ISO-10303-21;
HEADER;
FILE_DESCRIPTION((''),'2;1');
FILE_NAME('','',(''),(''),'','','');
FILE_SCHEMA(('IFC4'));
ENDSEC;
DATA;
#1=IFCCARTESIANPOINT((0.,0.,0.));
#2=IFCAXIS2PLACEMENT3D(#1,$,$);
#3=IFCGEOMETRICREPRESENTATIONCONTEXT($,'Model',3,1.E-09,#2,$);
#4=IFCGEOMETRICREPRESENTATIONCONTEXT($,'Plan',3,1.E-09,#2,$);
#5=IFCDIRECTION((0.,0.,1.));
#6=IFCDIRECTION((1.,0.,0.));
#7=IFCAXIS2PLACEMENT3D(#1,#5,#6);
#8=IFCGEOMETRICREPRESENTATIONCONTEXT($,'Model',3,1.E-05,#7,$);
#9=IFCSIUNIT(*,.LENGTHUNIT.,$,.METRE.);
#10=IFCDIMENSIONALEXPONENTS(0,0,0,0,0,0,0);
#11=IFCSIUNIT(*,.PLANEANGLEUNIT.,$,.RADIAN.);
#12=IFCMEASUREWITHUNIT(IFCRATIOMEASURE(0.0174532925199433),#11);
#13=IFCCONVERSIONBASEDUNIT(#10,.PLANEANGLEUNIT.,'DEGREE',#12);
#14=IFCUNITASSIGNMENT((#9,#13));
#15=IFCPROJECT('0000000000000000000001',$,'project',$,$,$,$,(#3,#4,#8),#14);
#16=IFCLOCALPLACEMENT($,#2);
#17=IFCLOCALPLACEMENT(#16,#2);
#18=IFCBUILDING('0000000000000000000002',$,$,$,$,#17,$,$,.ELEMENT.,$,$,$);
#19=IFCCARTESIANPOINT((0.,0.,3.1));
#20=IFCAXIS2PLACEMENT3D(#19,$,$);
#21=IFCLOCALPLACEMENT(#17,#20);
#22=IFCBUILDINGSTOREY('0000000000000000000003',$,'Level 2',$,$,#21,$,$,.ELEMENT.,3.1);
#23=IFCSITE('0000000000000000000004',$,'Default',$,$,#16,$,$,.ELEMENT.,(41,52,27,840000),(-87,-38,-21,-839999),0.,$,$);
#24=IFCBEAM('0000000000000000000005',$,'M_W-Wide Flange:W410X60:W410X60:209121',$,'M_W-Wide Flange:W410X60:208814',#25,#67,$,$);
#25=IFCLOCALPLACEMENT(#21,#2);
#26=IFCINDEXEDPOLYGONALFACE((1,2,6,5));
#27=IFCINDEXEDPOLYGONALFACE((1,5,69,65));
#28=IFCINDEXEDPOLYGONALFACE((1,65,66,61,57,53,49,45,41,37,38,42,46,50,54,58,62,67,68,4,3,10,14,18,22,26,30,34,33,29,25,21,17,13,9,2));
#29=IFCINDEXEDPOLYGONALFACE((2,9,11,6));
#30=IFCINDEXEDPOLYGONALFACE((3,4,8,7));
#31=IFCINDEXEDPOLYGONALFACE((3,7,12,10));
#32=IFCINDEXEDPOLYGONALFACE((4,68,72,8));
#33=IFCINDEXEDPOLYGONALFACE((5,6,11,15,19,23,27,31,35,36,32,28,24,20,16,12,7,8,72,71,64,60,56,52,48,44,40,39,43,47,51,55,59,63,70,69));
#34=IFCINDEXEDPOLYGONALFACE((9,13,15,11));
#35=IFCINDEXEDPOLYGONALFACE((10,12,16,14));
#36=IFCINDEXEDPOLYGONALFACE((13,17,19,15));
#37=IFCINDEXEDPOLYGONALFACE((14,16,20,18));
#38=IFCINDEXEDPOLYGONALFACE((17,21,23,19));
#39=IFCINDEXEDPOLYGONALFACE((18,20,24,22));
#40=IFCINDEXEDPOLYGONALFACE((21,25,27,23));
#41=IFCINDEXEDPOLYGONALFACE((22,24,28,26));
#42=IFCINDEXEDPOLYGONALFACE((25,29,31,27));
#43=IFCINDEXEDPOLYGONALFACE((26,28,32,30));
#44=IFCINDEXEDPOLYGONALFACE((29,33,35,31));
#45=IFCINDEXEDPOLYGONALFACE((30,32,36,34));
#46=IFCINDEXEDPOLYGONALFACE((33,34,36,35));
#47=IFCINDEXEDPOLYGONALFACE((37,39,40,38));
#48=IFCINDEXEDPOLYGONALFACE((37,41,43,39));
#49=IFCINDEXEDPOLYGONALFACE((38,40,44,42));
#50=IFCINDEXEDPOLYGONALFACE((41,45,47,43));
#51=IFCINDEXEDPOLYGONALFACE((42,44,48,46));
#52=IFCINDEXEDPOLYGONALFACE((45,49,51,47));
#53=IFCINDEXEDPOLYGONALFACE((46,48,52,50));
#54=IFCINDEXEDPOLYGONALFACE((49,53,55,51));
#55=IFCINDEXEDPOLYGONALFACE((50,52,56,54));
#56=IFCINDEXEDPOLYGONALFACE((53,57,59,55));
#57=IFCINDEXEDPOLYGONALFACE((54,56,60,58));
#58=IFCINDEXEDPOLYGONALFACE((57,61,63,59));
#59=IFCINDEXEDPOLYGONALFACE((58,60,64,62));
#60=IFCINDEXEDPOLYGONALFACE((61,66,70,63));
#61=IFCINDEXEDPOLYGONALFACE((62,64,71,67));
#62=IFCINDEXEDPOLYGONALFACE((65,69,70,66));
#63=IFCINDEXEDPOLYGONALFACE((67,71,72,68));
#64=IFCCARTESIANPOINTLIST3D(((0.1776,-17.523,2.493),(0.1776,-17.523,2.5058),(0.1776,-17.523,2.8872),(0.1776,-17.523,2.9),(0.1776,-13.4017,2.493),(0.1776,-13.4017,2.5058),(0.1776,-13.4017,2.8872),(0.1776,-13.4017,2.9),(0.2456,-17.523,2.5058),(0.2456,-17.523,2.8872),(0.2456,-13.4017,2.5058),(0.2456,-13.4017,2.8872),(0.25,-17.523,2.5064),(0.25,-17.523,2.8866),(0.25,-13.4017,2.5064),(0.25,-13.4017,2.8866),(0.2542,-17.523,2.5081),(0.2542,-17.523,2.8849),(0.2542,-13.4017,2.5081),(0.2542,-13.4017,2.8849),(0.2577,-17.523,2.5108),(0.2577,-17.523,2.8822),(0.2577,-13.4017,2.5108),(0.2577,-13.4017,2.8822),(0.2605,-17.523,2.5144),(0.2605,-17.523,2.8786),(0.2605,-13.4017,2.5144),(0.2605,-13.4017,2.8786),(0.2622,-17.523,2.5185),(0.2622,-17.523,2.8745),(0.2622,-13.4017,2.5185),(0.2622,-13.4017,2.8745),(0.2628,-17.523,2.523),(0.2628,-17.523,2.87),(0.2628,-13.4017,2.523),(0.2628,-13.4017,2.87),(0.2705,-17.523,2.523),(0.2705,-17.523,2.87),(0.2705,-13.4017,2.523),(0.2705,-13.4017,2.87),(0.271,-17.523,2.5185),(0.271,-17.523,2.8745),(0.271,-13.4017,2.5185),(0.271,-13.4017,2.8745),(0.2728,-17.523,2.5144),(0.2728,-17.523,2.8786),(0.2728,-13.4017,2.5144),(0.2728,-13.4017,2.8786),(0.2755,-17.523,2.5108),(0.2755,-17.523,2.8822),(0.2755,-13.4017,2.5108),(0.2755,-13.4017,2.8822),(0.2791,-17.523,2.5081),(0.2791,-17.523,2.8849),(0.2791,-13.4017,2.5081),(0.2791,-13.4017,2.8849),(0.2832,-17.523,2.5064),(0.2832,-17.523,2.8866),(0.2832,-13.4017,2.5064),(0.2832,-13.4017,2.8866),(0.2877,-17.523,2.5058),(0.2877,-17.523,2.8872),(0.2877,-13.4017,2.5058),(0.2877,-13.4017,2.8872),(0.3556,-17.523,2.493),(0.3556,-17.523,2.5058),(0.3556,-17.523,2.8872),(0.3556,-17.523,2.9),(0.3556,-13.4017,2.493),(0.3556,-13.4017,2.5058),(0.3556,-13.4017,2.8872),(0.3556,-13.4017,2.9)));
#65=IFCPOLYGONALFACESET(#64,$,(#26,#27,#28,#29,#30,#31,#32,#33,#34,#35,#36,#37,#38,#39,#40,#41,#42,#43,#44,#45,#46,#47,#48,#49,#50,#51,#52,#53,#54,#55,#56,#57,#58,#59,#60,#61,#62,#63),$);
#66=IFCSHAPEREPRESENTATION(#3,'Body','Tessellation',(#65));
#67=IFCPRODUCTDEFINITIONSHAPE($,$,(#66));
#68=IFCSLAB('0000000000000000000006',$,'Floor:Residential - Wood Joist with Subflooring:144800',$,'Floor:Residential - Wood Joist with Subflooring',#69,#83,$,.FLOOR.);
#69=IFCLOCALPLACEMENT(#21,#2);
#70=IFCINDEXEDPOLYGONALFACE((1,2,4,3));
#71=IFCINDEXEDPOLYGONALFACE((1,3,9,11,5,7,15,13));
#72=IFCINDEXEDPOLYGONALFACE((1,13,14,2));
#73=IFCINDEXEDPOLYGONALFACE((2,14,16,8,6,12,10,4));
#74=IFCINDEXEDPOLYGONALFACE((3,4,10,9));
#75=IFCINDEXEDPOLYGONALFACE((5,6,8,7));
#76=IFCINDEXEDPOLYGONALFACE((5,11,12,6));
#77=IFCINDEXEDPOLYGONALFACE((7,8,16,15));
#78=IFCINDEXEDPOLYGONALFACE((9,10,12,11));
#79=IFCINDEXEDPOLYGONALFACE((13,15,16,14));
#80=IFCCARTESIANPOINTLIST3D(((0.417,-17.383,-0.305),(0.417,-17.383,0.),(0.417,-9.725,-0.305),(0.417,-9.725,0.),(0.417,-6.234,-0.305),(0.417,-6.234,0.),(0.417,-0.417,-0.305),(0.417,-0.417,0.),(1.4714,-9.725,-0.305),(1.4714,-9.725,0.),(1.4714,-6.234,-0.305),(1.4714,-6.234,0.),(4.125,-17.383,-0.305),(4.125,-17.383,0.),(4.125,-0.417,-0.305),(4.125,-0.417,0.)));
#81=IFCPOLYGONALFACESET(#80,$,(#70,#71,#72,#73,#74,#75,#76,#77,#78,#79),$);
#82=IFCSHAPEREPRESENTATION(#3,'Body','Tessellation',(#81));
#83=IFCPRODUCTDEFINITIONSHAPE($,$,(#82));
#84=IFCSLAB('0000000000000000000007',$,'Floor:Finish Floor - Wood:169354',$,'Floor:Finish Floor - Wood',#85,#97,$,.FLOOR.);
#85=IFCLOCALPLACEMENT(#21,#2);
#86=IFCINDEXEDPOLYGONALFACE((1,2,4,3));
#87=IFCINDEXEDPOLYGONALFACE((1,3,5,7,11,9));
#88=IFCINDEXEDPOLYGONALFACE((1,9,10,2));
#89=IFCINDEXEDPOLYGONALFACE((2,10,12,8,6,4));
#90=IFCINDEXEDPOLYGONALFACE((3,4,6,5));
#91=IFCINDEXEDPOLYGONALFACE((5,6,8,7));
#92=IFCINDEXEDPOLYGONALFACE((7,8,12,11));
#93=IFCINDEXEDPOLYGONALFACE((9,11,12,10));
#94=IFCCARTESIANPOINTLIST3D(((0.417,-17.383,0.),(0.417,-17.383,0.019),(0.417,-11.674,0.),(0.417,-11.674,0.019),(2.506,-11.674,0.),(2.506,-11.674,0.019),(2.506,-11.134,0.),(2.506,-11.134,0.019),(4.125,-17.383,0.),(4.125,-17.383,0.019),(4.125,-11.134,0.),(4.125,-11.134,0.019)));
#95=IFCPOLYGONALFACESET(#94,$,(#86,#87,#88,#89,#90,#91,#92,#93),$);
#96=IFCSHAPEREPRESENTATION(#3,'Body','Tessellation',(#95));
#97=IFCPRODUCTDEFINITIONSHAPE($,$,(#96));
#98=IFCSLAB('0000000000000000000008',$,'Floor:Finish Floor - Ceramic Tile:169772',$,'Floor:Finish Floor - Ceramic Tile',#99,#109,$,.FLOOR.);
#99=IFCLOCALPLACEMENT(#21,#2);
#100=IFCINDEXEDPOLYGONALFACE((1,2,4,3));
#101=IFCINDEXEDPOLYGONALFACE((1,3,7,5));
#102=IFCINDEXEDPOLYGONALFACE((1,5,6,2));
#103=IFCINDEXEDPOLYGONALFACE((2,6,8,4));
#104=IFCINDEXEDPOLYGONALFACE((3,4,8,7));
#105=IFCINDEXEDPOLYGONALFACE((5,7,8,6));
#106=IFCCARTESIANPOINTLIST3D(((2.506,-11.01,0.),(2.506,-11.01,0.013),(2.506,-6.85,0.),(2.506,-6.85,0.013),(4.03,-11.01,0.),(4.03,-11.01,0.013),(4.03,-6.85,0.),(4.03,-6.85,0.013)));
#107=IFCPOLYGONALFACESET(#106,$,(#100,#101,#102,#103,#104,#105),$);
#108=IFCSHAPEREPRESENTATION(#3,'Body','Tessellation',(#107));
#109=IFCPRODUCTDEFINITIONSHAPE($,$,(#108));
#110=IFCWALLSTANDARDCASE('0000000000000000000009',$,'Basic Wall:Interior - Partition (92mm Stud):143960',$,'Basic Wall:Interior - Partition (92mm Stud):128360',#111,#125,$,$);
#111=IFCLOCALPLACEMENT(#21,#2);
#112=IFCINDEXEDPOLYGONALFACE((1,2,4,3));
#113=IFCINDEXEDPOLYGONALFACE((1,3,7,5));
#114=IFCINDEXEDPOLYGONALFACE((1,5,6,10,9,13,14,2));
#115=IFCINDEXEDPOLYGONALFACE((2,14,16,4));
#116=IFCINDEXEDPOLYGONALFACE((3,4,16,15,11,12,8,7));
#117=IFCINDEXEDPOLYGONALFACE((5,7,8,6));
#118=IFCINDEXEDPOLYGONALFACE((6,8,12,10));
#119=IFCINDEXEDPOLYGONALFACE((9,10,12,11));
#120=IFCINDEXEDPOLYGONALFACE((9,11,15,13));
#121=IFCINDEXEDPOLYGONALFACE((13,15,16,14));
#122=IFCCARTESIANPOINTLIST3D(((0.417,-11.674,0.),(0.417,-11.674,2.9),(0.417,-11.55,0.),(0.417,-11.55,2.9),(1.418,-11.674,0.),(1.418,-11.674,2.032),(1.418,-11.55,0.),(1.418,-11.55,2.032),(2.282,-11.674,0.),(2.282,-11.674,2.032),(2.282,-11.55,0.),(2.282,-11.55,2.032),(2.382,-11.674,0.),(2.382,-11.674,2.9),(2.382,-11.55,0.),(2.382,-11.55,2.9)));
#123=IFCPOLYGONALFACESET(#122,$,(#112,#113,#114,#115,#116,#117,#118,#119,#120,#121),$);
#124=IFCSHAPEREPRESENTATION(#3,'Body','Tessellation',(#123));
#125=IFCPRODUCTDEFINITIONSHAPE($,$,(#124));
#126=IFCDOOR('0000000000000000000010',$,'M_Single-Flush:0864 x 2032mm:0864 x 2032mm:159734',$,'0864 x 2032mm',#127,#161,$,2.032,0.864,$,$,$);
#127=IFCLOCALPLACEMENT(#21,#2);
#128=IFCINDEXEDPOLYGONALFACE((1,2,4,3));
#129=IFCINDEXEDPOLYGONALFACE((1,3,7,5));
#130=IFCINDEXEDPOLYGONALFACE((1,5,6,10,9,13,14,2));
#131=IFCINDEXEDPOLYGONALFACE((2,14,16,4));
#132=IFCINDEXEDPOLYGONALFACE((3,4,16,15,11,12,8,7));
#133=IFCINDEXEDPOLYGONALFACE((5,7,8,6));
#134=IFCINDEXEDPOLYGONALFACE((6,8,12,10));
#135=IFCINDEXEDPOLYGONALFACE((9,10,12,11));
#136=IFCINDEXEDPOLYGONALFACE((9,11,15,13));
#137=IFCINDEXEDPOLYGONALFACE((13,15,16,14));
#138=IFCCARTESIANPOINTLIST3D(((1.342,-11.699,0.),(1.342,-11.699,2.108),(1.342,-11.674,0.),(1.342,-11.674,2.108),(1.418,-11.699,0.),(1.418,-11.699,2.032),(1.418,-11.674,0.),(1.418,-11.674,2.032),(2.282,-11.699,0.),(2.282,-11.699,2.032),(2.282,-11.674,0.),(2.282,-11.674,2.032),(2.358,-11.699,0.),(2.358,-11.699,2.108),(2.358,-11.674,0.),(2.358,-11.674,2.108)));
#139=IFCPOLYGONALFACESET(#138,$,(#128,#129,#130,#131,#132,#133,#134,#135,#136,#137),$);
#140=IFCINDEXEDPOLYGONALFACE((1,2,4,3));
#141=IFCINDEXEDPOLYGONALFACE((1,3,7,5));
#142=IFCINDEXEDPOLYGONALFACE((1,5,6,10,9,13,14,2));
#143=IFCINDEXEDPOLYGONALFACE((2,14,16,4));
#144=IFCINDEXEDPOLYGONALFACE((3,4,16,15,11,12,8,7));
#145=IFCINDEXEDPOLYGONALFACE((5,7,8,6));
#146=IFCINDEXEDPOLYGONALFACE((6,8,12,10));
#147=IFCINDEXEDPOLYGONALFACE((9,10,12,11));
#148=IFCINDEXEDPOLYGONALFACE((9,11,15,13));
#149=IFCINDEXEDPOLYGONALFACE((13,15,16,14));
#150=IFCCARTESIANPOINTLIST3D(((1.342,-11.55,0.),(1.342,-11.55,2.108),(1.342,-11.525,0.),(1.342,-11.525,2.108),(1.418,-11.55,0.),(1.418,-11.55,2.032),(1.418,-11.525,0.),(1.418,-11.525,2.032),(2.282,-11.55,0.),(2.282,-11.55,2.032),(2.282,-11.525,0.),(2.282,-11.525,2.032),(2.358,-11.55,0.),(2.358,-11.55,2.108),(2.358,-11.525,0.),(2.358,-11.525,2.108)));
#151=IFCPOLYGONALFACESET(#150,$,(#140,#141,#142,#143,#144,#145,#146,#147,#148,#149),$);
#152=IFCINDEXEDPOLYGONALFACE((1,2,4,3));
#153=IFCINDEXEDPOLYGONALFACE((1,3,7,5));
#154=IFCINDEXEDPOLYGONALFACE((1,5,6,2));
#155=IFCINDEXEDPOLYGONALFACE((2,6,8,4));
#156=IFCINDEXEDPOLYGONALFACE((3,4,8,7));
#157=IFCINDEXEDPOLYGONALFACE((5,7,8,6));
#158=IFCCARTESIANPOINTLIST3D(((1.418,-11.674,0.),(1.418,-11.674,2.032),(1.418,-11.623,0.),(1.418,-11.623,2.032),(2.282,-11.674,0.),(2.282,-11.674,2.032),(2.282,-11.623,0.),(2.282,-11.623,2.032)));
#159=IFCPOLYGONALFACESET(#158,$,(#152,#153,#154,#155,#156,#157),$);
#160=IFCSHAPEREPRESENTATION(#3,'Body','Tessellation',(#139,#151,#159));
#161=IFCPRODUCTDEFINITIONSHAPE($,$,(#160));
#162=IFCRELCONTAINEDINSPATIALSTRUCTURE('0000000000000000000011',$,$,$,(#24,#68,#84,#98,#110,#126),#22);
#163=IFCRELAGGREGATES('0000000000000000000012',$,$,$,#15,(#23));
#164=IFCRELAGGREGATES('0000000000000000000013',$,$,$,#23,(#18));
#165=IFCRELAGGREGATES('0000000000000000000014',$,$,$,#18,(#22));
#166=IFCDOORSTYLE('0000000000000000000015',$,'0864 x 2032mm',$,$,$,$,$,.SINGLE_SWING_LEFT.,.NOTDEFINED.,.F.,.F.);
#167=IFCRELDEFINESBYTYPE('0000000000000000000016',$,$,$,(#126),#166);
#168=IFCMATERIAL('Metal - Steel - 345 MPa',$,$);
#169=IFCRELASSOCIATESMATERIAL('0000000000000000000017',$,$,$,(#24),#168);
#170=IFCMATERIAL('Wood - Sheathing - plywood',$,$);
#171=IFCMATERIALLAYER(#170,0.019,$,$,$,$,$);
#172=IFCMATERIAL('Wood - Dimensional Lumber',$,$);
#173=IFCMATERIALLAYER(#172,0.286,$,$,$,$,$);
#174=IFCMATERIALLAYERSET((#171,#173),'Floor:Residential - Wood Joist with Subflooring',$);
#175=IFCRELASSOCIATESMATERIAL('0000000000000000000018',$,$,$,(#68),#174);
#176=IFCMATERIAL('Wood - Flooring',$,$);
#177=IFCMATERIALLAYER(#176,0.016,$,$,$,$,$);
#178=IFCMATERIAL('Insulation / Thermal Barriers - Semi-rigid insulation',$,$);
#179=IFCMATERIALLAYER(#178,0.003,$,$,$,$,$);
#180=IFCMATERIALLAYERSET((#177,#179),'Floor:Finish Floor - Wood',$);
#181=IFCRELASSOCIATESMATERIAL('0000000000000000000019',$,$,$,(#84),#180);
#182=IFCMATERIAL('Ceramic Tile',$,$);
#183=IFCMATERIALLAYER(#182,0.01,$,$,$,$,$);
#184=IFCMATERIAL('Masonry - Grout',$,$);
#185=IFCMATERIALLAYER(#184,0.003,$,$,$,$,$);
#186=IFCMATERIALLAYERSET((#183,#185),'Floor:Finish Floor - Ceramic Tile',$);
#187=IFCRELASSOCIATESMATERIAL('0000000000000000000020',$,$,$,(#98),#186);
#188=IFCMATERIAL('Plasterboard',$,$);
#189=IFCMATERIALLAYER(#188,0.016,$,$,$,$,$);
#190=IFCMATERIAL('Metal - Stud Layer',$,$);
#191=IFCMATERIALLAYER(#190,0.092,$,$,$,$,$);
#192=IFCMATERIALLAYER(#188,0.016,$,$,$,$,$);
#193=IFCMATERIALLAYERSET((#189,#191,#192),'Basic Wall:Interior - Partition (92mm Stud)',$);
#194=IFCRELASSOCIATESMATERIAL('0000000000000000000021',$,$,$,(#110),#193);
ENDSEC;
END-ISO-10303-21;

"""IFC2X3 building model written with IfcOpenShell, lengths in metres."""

from ifc_helpers import new_model, entity, si_unit, converted_unit, frame, frame_2d, origin, origin_with_axes, origin_2d_with_axis, place, context, project, spatial, polyline, circle_curve, parameter, trimmed, segment, composite_curve, rectangle, outline, extrude, source, transform, mapped, material, layer, layer_set, layer_usage, type_object, type_shapes, element, fill, save


model = new_model("IFC2X3")

# Units and contexts
model_context_1 = context("Model", 3, precision=1e-09, world=origin())
plan_context = context("Plan", 3, precision=1e-09, world=origin())
model_context_2 = context("Model", 3, precision=1e-05, world=origin_with_axes())
ifc_project = project(units=[si_unit("LENGTHUNIT", "METRE"), converted_unit("PLANEANGLEUNIT", "DEGREE", entity("IfcRatioMeasure", 0.0174532925199433), si_unit("PLANEANGLEUNIT", "RADIAN"), dimensions=[0, 0, 0, 0, 0, 0, 0])], contexts=[model_context_1, plan_context, model_context_2])

# Site, building, storey
site_placement = place(None, origin())
site = spatial("IfcSite", under=ifc_project, at=site_placement, Name="Default", CompositionType="ELEMENT", RefLatitude=(41, 52, 27, 840000), RefLongitude=(-87, -38, -21, -839999), RefElevation=0.0)
building_placement = place(site_placement, origin())
building = spatial("IfcBuilding", under=site, at=building_placement, CompositionType="ELEMENT")
storey_placement = place(building_placement, frame((0.0, 0.0, 3.1)))
storey = spatial("IfcBuildingStorey", under=building, at=storey_placement, Name="Level 2", CompositionType="ELEMENT", Elevation=3.1)

# Beam
ifc_material_1 = material(Name="Metal - Steel - 345 MPa")
beam_placement = place(storey_placement, frame((0.2666, -13.4017, 2.9), z_axis=(0.0, 0.0, 1.0), x_axis=(-1.0, 0.0, 0.0)))
element("IfcBeam", 1, at=beam_placement, inside=storey, material=ifc_material_1, Name="M_W-Wide Flange:W410X60:W410X60:209121", ObjectType="M_W-Wide Flange:W410X60:208814", context=model_context_1, shape_type="SweptSolid", body=[
    extrude(outline(composite_curve([segment(polyline([(0.1907, -0.089), (0.2035, -0.089)]), True, "CONTINUOUS"), segment(polyline([(0.2035, -0.089), (0.2035, 0.089)]), True, "CONTINUOUS"), segment(polyline([(0.2035, 0.089), (0.1907, 0.089)]), True, "CONTINUOUS"), segment(polyline([(0.1907, 0.089), (0.1907, 0.021)]), True, "CONTINUOUS"), segment(trimmed(circle_curve(frame_2d((0.1735, 0.021), x_axis=(1.0, 0.0)), 0.0172), [parameter(270.0)], [parameter(360.0)], True, "PARAMETER"), False, "CONTINUOUS"), segment(polyline([(0.1735, 0.0038), (-0.1735, 0.0038)]), True, "CONTINUOUS"), segment(trimmed(circle_curve(frame_2d((-0.1735, 0.021), x_axis=(0.0, -1.0)), 0.0172), [parameter(270.0)], [parameter(360.0)], True, "PARAMETER"), False, "CONTINUOUS"), segment(polyline([(-0.1907, 0.021), (-0.1907, 0.089)]), True, "CONTINUOUS"), segment(polyline([(-0.1907, 0.089), (-0.2035, 0.089)]), True, "CONTINUOUS"), segment(polyline([(-0.2035, 0.089), (-0.2035, -0.089)]), True, "CONTINUOUS"), segment(polyline([(-0.2035, -0.089), (-0.1907, -0.089)]), True, "CONTINUOUS"), segment(polyline([(-0.1907, -0.089), (-0.1907, -0.0211)]), True, "CONTINUOUS"), segment(trimmed(circle_curve(frame_2d((-0.1735, -0.0211), x_axis=(-1.0, 0.0)), 0.0172), [parameter(270.0)], [parameter(0.0)], True, "PARAMETER"), False, "CONTINUOUS"), segment(polyline([(-0.1735, -0.0039), (0.1735, -0.0039)]), True, "CONTINUOUS"), segment(trimmed(circle_curve(frame_2d((0.1735, -0.0211), x_axis=(0.0, 1.0)), 0.0172), [parameter(270.0)], [parameter(0.0)], True, "PARAMETER"), False, "CONTINUOUS"), segment(polyline([(0.1907, -0.0211), (0.1907, -0.089)]), True, "CONTINUOUS")], self_intersect=False)), frame((0.0, 4.1213, -0.2035), z_axis=(0.0, -1.0, 0.0), x_axis=(0.0, 0.0, -1.0)), (0.0, 0.0, 1.0), 4.1213),
])

# Slabs
ifc_material_2 = material(Name="Wood - Sheathing - plywood")
ifc_layer_1 = layer(ifc_material_2, 0.019)
ifc_material_3 = material(Name="Wood - Dimensional Lumber")
ifc_layer_2 = layer(ifc_material_3, 0.286)
ifc_layer_set_1 = layer_set([ifc_layer_1, ifc_layer_2], Name="Floor:Residential - Wood Joist with Subflooring")
ifc_layer_usage_1 = layer_usage(ifc_layer_set_1, "AXIS3", "POSITIVE", 0.0)
slab_1_placement = place(storey_placement, frame((0.417, -17.383, -0.305)))
element("IfcSlab", 2, at=slab_1_placement, inside=storey, material=ifc_layer_usage_1, Name="Floor:Residential - Wood Joist with Subflooring:144800", ObjectType="Floor:Residential - Wood Joist with Subflooring", PredefinedType="FLOOR", context=model_context_1, shape_type="SweptSolid", body=[
    extrude(outline(polyline([(-1.854, 8.483), (-1.854, -8.483), (1.854, -8.483), (1.854, -0.825), (0.7996, -0.825), (0.7996, 2.666), (1.854, 2.666), (1.854, 8.483), (-1.854, 8.483)])), frame((1.854, 8.483, 0.305), z_axis=(0.0, 0.0, -1.0), x_axis=(-1.0, 0.0, 0.0)), (0.0, 0.0, 1.0), 0.305),
])
ifc_material_4 = material(Name="Wood - Flooring")
ifc_layer_3 = layer(ifc_material_4, 0.016)
ifc_material_5 = material(Name="Insulation / Thermal Barriers - Semi-rigid insulation")
ifc_layer_4 = layer(ifc_material_5, 0.003)
ifc_layer_set_2 = layer_set([ifc_layer_3, ifc_layer_4], Name="Floor:Finish Floor - Wood")
ifc_layer_usage_2 = layer_usage(ifc_layer_set_2, "AXIS3", "POSITIVE", 0.0)
slab_2_placement = place(storey_placement, frame((0.417, -17.383, 0.0)))
element("IfcSlab", 3, at=slab_2_placement, inside=storey, material=ifc_layer_usage_2, Name="Floor:Finish Floor - Wood:169354", ObjectType="Floor:Finish Floor - Wood", PredefinedType="FLOOR", context=model_context_1, shape_type="SweptSolid", body=[
    extrude(outline(polyline([(-1.854, -3.1245), (1.854, -3.1245), (1.854, 2.5845), (-0.235, 2.5845), (-0.235, 3.1245), (-1.854, 3.1245), (-1.854, -3.1245)])), frame((1.854, 3.1245, 0.019), z_axis=(0.0, 0.0, -1.0), x_axis=(-1.0, 0.0, 0.0)), (0.0, 0.0, 1.0), 0.019),
])
ifc_material_6 = material(Name="Ceramic Tile")
ifc_layer_5 = layer(ifc_material_6, 0.01)
ifc_material_7 = material(Name="Masonry - Grout")
ifc_layer_6 = layer(ifc_material_7, 0.003)
ifc_layer_set_3 = layer_set([ifc_layer_5, ifc_layer_6], Name="Floor:Finish Floor - Ceramic Tile")
ifc_layer_usage_3 = layer_usage(ifc_layer_set_3, "AXIS3", "POSITIVE", 0.0)
slab_3_placement = place(storey_placement, frame((2.506, -11.01, 0.0)))
element("IfcSlab", 4, at=slab_3_placement, inside=storey, material=ifc_layer_usage_3, Name="Floor:Finish Floor - Ceramic Tile:169772", ObjectType="Floor:Finish Floor - Ceramic Tile", PredefinedType="FLOOR", context=model_context_1, shape_type="SweptSolid", body=[
    extrude(rectangle(XDim=4.16, YDim=1.524, at=frame_2d((0.0, 0.0), x_axis=(0.0, -1.0))), frame((0.762, 2.08, 0.013), z_axis=(0.0, 0.0, -1.0), x_axis=(-1.0, 0.0, 0.0)), (0.0, 0.0, 1.0), 0.013),
])

# Shared definitions
ifc_material_8 = material(Name="Metal - Stud Layer")
ifc_material_9 = material(Name="Plasterboard")

# Wall, opening, door
ifc_layer_7 = layer(ifc_material_9, 0.016)
ifc_layer_8 = layer(ifc_material_8, 0.092)
ifc_layer_9 = layer(ifc_material_9, 0.016)
ifc_layer_set_4 = layer_set([ifc_layer_7, ifc_layer_8, ifc_layer_9], Name="Basic Wall:Interior - Partition (92mm Stud)")
ifc_layer_usage_4 = layer_usage(ifc_layer_set_4, "AXIS2", "NEGATIVE", 0.062)
wall_1_placement = place(storey_placement, frame((2.382, -11.612, 0.0), z_axis=(0.0, 0.0, 1.0), x_axis=(-1.0, 0.0, 0.0)))
wall_1 = element("IfcWallStandardCase", 5, at=wall_1_placement, inside=storey, material=ifc_layer_usage_4, Name="Basic Wall:Interior - Partition (92mm Stud):143960", ObjectType="Basic Wall:Interior - Partition (92mm Stud):128360", context=model_context_1, shape_type="SweptSolid", body=[
    extrude(rectangle(XDim=1.965, YDim=0.124, at=frame_2d((0.9825, 0.0), x_axis=(-1.0, 0.0))), origin(), (0.0, 0.0, 1.0), 2.9),
])
opening_1_placement = place(wall_1_placement, frame((0.1, -0.062, 0.0)))
opening_1 = element("IfcOpeningElement", 6, at=opening_1_placement, cuts=wall_1, ObjectType="Opening", context=model_context_1, shape_type="SweptSolid", body=[
    extrude(rectangle(XDim=0.864, YDim=2.032, at=frame_2d((1.016, 0.432), x_axis=(0.0, -1.0))), frame((0.0, 0.0, 0.0), z_axis=(0.0, 1.0, 0.0), x_axis=(0.0, 0.0, 1.0)), (0.0, 0.0, 1.0), 0.124),
])
door_style = type_object("IfcDoorStyle", Name="0864 x 2032mm", ConstructionType="NOTDEFINED", OperationType="SINGLE_SWING_LEFT", ParameterTakesPrecedence=False, Sizeable=False)
shared_shape_1 = source(origin(), model_context_1, "Body", "SweptSolid", [
    extrude(outline(polyline([(-0.508, -1.073), (0.508, -1.073), (0.508, 1.035), (0.432, 1.035), (0.432, -0.997), (-0.432, -0.997), (-0.432, 1.035), (-0.508, 1.035), (-0.508, -1.073)])), frame((0.432, 0.149, 1.035), z_axis=(0.0, -1.0, 0.0), x_axis=(-1.0, 0.0, 0.0)), (0.0, 0.0, 1.0), 0.025),
    extrude(outline(polyline([(-1.073, -0.508), (1.035, -0.508), (1.035, -0.432), (-0.997, -0.432), (-0.997, 0.432), (1.035, 0.432), (1.035, 0.508), (-1.073, 0.508), (-1.073, -0.508)])), frame((0.432, 0.0, 1.035), z_axis=(0.0, -1.0, 0.0), x_axis=(0.0, 0.0, -1.0)), (0.0, 0.0, 1.0), 0.025),
    extrude(rectangle(XDim=0.864, YDim=0.051, at=origin_2d_with_axis()), frame((0.432, 0.0985, 0.0)), (0.0, 0.0, 1.0), 2.032),
])
type_shapes(door_style, [shared_shape_1])
door_placement = place(opening_1_placement, origin())
door = element("IfcDoor", 7, at=door_placement, inside=storey, type_object=door_style, Name="M_Single-Flush:0864 x 2032mm:0864 x 2032mm:159734", ObjectType="0864 x 2032mm", OverallHeight=2.032, OverallWidth=0.864, context=model_context_1, shape_type="MappedRepresentation", body=[
    mapped(shared_shape_1, transform((0.0, 0.0, 0.0), scale=1.0)),
])
fill(opening_1, door)

save(model, "model.ifc")
